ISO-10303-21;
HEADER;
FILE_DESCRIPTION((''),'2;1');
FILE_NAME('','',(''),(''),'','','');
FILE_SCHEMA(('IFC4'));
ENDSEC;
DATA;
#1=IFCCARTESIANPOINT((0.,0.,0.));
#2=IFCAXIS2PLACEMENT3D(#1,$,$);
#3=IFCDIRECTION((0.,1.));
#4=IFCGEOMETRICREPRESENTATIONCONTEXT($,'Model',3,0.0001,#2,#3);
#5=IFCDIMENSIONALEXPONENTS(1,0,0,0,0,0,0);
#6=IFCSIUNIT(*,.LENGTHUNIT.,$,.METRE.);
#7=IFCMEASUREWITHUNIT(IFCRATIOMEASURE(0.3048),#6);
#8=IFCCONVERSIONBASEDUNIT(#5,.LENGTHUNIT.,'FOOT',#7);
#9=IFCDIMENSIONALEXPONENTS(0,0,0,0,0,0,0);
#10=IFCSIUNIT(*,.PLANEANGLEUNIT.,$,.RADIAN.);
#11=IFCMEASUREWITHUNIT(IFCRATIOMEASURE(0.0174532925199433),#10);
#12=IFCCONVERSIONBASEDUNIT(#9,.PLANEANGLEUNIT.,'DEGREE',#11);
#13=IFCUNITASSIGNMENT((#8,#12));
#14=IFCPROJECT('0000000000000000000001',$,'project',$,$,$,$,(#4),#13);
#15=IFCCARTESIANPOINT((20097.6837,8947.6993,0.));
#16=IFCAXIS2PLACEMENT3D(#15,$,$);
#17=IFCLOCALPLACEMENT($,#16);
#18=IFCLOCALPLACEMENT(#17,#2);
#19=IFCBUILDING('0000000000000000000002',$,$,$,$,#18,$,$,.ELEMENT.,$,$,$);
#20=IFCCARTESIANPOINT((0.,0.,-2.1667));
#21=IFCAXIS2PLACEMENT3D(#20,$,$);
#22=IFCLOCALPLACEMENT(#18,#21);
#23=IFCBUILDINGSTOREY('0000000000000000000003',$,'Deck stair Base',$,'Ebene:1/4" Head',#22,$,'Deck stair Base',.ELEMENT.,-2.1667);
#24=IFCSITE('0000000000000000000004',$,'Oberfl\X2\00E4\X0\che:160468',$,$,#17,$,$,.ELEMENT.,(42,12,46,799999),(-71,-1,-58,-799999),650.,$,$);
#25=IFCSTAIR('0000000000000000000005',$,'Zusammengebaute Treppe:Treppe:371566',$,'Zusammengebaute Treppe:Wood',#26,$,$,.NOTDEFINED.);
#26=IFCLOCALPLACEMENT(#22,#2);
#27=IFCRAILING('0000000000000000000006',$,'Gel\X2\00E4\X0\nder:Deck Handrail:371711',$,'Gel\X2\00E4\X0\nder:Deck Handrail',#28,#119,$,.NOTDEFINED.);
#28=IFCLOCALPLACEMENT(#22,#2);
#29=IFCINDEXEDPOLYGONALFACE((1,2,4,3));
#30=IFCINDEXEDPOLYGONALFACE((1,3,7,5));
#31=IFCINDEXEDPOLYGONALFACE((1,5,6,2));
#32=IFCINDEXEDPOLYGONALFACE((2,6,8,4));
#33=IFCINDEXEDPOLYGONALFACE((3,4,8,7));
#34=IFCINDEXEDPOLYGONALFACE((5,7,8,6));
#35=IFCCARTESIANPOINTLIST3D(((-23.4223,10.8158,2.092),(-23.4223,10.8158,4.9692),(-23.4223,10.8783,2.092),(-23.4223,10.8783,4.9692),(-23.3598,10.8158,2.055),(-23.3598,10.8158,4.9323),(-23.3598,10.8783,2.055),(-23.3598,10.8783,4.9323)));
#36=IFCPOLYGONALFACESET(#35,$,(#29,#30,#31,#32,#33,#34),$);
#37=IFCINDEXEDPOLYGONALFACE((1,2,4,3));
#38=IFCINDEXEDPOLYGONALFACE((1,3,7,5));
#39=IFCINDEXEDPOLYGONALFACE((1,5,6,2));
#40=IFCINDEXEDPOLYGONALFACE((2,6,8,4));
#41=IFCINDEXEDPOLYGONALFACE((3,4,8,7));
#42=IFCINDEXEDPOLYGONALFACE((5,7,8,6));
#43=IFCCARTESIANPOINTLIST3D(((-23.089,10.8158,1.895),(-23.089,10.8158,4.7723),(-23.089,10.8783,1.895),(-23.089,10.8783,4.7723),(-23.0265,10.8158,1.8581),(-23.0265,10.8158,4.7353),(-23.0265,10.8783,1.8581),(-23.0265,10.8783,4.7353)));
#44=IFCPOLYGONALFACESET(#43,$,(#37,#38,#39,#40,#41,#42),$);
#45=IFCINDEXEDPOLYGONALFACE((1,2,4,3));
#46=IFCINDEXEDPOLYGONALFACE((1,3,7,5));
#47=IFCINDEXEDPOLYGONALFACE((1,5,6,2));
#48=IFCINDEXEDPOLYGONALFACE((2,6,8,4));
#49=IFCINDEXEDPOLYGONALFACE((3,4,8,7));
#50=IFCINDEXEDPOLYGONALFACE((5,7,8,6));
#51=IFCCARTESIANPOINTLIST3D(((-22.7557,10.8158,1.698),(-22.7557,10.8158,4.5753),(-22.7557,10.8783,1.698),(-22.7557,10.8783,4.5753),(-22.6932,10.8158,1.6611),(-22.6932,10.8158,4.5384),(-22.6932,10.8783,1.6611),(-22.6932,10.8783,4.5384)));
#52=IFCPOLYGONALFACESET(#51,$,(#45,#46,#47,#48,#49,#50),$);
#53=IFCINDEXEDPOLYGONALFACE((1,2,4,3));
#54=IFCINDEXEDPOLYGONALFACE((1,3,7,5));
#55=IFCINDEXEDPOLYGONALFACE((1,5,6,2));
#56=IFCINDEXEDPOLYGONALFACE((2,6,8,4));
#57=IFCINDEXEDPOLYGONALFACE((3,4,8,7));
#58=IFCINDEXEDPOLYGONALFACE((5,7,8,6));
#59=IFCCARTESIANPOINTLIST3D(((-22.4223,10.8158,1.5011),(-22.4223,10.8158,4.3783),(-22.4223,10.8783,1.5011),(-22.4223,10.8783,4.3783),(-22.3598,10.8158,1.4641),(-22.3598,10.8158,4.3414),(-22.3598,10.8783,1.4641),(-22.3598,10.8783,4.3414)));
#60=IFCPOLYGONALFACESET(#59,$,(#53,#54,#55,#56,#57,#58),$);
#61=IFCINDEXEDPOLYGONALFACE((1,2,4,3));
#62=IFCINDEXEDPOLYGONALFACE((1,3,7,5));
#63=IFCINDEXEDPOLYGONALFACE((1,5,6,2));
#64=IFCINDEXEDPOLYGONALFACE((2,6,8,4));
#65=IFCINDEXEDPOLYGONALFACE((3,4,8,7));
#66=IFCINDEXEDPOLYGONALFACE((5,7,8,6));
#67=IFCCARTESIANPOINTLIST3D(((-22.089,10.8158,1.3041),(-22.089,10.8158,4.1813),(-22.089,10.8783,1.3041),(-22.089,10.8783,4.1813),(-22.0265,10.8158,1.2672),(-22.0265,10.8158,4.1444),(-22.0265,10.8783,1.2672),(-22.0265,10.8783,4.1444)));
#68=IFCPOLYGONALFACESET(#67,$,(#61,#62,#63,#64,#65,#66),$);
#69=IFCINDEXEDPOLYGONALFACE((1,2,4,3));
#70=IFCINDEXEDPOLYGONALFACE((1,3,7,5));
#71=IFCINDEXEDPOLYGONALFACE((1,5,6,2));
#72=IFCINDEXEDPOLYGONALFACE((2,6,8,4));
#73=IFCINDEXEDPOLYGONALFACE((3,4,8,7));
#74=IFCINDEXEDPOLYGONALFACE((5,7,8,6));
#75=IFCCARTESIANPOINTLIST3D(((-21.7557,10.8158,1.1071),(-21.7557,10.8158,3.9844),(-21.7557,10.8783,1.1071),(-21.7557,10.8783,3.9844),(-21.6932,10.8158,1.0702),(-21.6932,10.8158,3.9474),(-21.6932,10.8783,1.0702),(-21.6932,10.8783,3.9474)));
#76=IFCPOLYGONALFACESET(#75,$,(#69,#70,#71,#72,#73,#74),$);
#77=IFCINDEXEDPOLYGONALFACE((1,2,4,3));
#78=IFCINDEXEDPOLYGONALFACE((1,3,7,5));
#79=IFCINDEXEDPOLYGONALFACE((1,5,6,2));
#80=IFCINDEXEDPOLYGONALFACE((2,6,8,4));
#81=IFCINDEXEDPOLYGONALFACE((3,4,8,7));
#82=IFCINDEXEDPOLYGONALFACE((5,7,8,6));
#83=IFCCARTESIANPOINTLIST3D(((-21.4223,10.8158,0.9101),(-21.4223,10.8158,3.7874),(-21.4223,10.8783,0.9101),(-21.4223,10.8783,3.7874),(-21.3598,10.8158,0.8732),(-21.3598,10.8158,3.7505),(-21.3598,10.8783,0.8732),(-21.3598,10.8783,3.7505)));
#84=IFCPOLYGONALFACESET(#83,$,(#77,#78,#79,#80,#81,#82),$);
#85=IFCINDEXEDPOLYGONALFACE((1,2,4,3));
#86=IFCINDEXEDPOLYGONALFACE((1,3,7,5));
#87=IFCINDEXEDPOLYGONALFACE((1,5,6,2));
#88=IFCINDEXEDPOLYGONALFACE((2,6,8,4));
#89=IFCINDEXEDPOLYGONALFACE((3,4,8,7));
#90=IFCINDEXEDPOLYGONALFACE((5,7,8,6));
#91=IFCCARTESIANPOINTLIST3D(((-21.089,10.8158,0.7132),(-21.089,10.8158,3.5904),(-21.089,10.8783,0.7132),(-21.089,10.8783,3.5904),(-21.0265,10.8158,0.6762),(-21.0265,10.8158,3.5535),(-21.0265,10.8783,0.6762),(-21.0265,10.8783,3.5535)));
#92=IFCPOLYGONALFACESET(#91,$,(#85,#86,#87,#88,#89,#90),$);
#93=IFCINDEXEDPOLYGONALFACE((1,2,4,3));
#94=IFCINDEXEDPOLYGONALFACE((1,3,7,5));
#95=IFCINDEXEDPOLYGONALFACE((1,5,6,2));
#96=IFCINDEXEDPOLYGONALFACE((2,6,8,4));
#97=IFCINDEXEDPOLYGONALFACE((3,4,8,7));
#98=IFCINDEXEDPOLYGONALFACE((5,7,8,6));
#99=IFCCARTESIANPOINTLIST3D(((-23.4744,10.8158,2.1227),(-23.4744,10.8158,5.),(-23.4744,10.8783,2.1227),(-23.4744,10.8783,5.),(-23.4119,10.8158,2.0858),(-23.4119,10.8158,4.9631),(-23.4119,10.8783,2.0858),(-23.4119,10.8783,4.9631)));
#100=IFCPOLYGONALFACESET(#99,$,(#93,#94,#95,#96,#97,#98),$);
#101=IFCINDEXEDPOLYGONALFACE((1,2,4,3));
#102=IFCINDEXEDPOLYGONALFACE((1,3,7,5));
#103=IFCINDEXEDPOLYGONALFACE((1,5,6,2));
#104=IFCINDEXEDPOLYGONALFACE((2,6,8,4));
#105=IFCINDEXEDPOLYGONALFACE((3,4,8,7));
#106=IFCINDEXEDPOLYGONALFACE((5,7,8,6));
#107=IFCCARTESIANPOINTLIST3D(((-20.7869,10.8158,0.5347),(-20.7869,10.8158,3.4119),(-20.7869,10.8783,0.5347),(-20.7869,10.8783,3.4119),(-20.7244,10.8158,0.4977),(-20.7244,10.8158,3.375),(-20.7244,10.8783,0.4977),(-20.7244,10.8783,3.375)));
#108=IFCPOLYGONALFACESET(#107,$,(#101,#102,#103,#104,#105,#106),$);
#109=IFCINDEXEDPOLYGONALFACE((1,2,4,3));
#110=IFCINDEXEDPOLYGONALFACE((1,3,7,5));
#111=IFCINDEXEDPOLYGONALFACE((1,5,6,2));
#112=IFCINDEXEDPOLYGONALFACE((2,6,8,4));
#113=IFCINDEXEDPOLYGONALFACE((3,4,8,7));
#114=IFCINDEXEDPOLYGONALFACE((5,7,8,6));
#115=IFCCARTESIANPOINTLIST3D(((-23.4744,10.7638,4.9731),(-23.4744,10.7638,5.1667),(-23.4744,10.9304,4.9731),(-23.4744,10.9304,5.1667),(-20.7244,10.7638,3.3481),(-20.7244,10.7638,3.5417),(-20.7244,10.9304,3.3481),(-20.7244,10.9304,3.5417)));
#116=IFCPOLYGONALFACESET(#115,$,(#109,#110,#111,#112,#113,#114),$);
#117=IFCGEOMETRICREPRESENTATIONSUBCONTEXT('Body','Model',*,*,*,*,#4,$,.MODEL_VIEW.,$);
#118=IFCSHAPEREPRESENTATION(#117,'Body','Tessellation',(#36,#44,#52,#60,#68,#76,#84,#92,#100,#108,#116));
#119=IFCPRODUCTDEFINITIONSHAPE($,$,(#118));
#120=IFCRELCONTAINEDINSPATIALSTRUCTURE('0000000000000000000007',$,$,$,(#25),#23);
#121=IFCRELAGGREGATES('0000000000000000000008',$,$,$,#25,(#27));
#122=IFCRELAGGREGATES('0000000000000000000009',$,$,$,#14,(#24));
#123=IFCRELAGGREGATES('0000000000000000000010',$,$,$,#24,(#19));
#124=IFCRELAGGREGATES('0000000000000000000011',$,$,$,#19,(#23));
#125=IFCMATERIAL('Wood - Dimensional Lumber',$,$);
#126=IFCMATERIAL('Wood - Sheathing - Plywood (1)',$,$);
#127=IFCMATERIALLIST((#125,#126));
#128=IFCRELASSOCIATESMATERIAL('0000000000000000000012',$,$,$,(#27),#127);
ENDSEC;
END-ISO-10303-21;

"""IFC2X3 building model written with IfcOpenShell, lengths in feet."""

from ifc_helpers import new_model, entity, si_unit, converted_unit, direction, frame, origin, place, context, subcontext, project, spatial, polyline, outline, extrude, material, material_list, element, aggregate, save


model = new_model("IFC2X3")

# Units and contexts
model_context = context("Model", 3, precision=0.0001, world=origin(), true_north=direction((0.0, 1.0)))
body_context = subcontext(model_context, "Body", "Model", "MODEL_VIEW")
ifc_project = project(units=[converted_unit("LENGTHUNIT", "FOOT", entity("IfcRatioMeasure", 0.3048), si_unit("LENGTHUNIT", "METRE"), dimensions=[1, 0, 0, 0, 0, 0, 0]), converted_unit("PLANEANGLEUNIT", "DEGREE", entity("IfcRatioMeasure", 0.0174532925199433), si_unit("PLANEANGLEUNIT", "RADIAN"), dimensions=[0, 0, 0, 0, 0, 0, 0])], contexts=[model_context])

# Site, building, storey
site_placement = place(None, frame((20097.6837, 8947.6993, 0.0)))
site = spatial("IfcSite", under=ifc_project, at=site_placement, Name="Oberfläche:160468", CompositionType="ELEMENT", RefLatitude=(42, 12, 46, 799999), RefLongitude=(-71, -1, -58, -799999), RefElevation=650.0)
building_placement = place(site_placement, origin())
building = spatial("IfcBuilding", under=site, at=building_placement, CompositionType="ELEMENT")
storey_placement = place(building_placement, frame((0.0, 0.0, -2.1667)))
storey = spatial("IfcBuildingStorey", under=building, at=storey_placement, Name="Deck stair Base", ObjectType="Ebene:1/4\" Head", LongName="Deck stair Base", CompositionType="ELEMENT", Elevation=-2.1667)

# Stair, railing
stair_placement = place(storey_placement, origin())
stair = element("IfcStair", 1, at=stair_placement, inside=storey, Name="Zusammengebaute Treppe:Treppe:371566", ObjectType="Zusammengebaute Treppe:Wood", ShapeType="NOTDEFINED")
ifc_material_1 = material(Name="Wood - Dimensional Lumber")
ifc_material_2 = material(Name="Wood - Sheathing - Plywood (1)")
ifc_material_list = material_list([ifc_material_1, ifc_material_2])
railing_placement = place(stair_placement, origin())
railing = element("IfcRailing", 2, at=railing_placement, material=ifc_material_list, Name="Geländer:Deck Handrail:371711", ObjectType="Geländer:Deck Handrail", PredefinedType="NOTDEFINED", context=body_context, shape_type="SweptSolid", body=[
    extrude(outline(polyline([(-1.4202, -0.0312), (1.4571, -0.0312), (1.4202, 0.0312), (-1.4571, 0.0312), (-1.4202, -0.0312)])), frame((-23.3911, 10.8158, 3.5121), z_axis=(0.0, 1.0, 0.0), x_axis=(0.0, 0.0, -1.0)), (0.0, 0.0, 1.0), 0.0625),
    extrude(outline(polyline([(-1.4202, -0.0312), (1.4571, -0.0312), (1.4202, 0.0312), (-1.4571, 0.0312), (-1.4202, -0.0312)])), frame((-23.0578, 10.8158, 3.3152), z_axis=(0.0, 1.0, 0.0), x_axis=(0.0, 0.0, -1.0)), (0.0, 0.0, 1.0), 0.0625),
    extrude(outline(polyline([(-1.4202, -0.0312), (1.4571, -0.0312), (1.4202, 0.0312), (-1.4571, 0.0312), (-1.4202, -0.0312)])), frame((-22.7244, 10.8158, 3.1182), z_axis=(0.0, 1.0, 0.0), x_axis=(0.0, 0.0, -1.0)), (0.0, 0.0, 1.0), 0.0625),
    extrude(outline(polyline([(-1.4202, -0.0312), (1.4571, -0.0312), (1.4202, 0.0312), (-1.4571, 0.0312), (-1.4202, -0.0312)])), frame((-22.3911, 10.8158, 2.9212), z_axis=(0.0, 1.0, 0.0), x_axis=(0.0, 0.0, -1.0)), (0.0, 0.0, 1.0), 0.0625),
    extrude(outline(polyline([(-1.4202, -0.0312), (1.4571, -0.0312), (1.4202, 0.0312), (-1.4571, 0.0312), (-1.4202, -0.0312)])), frame((-22.0578, 10.8158, 2.7242), z_axis=(0.0, 1.0, 0.0), x_axis=(0.0, 0.0, -1.0)), (0.0, 0.0, 1.0), 0.0625),
    extrude(outline(polyline([(-1.4202, -0.0312), (1.4571, -0.0312), (1.4202, 0.0312), (-1.4571, 0.0312), (-1.4202, -0.0312)])), frame((-21.7244, 10.8158, 2.5273), z_axis=(0.0, 1.0, 0.0), x_axis=(0.0, 0.0, -1.0)), (0.0, 0.0, 1.0), 0.0625),
    extrude(outline(polyline([(-1.4202, -0.0312), (1.4571, -0.0312), (1.4202, 0.0312), (-1.4571, 0.0312), (-1.4202, -0.0312)])), frame((-21.3911, 10.8158, 2.3303), z_axis=(0.0, 1.0, 0.0), x_axis=(0.0, 0.0, -1.0)), (0.0, 0.0, 1.0), 0.0625),
    extrude(outline(polyline([(-1.4202, -0.0312), (1.4571, -0.0312), (1.4202, 0.0312), (-1.4571, 0.0312), (-1.4202, -0.0312)])), frame((-21.0578, 10.8158, 2.1333), z_axis=(0.0, 1.0, 0.0), x_axis=(0.0, 0.0, -1.0)), (0.0, 0.0, 1.0), 0.0625),
    extrude(outline(polyline([(-1.4202, -0.0312), (1.4571, -0.0312), (1.4202, 0.0312), (-1.4571, 0.0312), (-1.4202, -0.0312)])), frame((-23.4432, 10.8158, 3.5429), z_axis=(0.0, 1.0, 0.0), x_axis=(0.0, 0.0, -1.0)), (0.0, 0.0, 1.0), 0.0625),
    extrude(outline(polyline([(-1.4202, -0.0312), (1.4571, -0.0312), (1.4202, 0.0312), (-1.4571, 0.0312), (-1.4202, -0.0312)])), frame((-20.7557, 10.8158, 1.9548), z_axis=(0.0, 1.0, 0.0), x_axis=(0.0, 0.0, -1.0)), (0.0, 0.0, 1.0), 0.0625),
    extrude(outline(polyline([(-1.6464, -0.0833), (1.5479, -0.0833), (1.6464, 0.0833), (-1.5479, 0.0833), (-1.6464, -0.0833)])), frame((-22.0994, 10.7638, 4.2574), z_axis=(0.0, 1.0, 0.0), x_axis=(-0.860927, 0.0, 0.508729)), (0.0, 0.0, 1.0), 0.1667),
])
aggregate(stair, [railing])

save(model, "model.ifc")
